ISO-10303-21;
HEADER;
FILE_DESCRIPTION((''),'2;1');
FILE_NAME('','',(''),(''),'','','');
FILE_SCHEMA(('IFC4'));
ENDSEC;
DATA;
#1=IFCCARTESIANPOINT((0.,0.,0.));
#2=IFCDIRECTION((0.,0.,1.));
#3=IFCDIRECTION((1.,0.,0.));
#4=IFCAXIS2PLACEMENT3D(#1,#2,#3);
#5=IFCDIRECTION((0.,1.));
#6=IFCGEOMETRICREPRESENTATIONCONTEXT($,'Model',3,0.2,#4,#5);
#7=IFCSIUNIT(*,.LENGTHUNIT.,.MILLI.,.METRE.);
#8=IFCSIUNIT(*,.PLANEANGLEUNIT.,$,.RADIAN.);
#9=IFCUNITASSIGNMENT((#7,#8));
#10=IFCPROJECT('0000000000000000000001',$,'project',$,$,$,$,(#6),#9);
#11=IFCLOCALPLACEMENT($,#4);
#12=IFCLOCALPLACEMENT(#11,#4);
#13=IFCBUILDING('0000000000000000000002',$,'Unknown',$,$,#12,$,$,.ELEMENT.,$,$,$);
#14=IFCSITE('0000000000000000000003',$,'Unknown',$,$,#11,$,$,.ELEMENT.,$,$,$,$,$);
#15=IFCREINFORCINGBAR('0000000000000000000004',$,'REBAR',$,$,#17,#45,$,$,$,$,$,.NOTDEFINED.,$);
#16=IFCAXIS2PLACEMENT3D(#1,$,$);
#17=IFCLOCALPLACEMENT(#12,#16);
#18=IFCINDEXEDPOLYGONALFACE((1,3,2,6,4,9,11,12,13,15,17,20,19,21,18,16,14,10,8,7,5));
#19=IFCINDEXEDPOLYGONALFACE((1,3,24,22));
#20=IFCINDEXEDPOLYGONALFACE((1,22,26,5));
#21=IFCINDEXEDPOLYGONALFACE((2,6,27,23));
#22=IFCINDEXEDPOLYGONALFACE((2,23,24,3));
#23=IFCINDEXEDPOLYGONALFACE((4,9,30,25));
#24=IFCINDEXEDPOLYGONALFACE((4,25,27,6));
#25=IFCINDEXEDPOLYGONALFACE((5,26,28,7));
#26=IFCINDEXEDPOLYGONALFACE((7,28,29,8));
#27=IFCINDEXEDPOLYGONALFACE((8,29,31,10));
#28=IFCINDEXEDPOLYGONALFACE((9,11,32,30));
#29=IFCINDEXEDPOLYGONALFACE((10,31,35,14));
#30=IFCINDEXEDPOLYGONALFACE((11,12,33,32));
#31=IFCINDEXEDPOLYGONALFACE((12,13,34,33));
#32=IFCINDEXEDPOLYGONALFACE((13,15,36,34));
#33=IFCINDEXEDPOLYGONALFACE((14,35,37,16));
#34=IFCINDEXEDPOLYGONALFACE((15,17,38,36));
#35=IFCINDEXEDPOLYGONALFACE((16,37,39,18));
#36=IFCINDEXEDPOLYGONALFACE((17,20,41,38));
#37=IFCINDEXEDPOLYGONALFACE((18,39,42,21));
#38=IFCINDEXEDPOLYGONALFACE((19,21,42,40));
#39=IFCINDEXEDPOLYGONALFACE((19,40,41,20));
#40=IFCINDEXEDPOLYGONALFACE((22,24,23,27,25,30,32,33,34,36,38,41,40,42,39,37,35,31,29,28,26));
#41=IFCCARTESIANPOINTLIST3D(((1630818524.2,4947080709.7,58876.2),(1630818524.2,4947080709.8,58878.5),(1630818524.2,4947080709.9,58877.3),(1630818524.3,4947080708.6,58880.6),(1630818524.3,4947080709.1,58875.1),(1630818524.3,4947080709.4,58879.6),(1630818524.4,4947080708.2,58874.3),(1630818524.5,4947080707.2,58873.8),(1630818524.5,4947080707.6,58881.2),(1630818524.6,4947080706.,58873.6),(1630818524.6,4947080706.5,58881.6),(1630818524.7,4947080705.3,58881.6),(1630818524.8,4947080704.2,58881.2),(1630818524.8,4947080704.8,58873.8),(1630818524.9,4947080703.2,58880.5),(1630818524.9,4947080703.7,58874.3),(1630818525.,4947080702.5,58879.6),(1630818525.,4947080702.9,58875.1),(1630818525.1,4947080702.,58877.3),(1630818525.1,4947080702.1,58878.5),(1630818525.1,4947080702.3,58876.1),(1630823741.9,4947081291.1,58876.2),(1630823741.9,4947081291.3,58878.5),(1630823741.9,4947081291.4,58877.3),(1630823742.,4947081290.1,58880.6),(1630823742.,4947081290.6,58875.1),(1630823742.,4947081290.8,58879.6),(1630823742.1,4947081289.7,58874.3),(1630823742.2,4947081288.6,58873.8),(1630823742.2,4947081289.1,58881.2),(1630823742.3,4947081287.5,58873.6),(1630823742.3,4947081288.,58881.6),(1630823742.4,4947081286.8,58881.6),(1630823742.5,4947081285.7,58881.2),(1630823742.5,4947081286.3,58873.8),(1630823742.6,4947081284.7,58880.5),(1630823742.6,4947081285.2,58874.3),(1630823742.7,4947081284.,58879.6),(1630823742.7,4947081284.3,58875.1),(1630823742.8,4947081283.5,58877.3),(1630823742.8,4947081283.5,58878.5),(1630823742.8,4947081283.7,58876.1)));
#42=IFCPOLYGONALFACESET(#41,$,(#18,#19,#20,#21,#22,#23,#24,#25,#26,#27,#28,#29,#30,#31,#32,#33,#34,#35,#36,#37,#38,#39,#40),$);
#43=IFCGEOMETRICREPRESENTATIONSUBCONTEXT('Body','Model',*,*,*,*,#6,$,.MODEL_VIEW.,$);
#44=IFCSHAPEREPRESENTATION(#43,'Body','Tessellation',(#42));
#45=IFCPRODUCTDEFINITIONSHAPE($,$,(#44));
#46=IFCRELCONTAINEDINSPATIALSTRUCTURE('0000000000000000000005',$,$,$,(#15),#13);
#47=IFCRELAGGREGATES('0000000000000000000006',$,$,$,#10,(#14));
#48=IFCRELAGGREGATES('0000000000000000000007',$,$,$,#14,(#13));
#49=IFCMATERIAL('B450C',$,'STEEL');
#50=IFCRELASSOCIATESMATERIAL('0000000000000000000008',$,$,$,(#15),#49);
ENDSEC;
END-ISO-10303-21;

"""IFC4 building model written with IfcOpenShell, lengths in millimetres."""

from ifc_helpers import new_model, entity, si_unit, direction, frame, origin_with_axes, place, context, subcontext, project, spatial, material, element, save


model = new_model("IFC4")

# Units and contexts
model_context = context("Model", 3, precision=0.2, world=origin_with_axes(), true_north=direction((0.0, 1.0)))
body_context = subcontext(model_context, "Body", "Model", "MODEL_VIEW")
ifc_project = project(units=[si_unit("LENGTHUNIT", "METRE", prefix="MILLI"), si_unit("PLANEANGLEUNIT", "RADIAN")], contexts=[model_context])

# Site, building
site_placement = place(None, origin_with_axes())
site = spatial("IfcSite", under=ifc_project, at=site_placement, Name="Unknown", CompositionType="ELEMENT")
building_placement = place(site_placement, origin_with_axes())
building = spatial("IfcBuilding", under=site, at=building_placement, Name="Unknown", CompositionType="ELEMENT")

# Reinforcing bar
ifc_material = material(Name="B450C", Category="STEEL")
for number, where, z_axis, x_axis, name in (
    (1, (1630818524.6, 4947080705.9, 58877.6), (-0.007106, 0.063762, 0.99794), (0.993847, 0.110757, 0.0), "REBAR"),
):
    element("IfcReinforcingBar", number, at=place(building_placement, frame(where, z_axis=z_axis, x_axis=x_axis)), inside=building, material=ifc_material, Name=name, PredefinedType="NOTDEFINED", context=body_context, shape_type="AdvancedSweptSolid", body=[
        entity("IfcSweptDiskSolid", entity("IfcIndexedPolyCurve", entity("IfcCartesianPointList3D", [[0.0, 0.0, 0.0], [5250.0, 0.0, 0.0]]), [entity("IfcLineIndex", [1, 2])]), 4.0),
    ])

save(model, "model.ifc")
